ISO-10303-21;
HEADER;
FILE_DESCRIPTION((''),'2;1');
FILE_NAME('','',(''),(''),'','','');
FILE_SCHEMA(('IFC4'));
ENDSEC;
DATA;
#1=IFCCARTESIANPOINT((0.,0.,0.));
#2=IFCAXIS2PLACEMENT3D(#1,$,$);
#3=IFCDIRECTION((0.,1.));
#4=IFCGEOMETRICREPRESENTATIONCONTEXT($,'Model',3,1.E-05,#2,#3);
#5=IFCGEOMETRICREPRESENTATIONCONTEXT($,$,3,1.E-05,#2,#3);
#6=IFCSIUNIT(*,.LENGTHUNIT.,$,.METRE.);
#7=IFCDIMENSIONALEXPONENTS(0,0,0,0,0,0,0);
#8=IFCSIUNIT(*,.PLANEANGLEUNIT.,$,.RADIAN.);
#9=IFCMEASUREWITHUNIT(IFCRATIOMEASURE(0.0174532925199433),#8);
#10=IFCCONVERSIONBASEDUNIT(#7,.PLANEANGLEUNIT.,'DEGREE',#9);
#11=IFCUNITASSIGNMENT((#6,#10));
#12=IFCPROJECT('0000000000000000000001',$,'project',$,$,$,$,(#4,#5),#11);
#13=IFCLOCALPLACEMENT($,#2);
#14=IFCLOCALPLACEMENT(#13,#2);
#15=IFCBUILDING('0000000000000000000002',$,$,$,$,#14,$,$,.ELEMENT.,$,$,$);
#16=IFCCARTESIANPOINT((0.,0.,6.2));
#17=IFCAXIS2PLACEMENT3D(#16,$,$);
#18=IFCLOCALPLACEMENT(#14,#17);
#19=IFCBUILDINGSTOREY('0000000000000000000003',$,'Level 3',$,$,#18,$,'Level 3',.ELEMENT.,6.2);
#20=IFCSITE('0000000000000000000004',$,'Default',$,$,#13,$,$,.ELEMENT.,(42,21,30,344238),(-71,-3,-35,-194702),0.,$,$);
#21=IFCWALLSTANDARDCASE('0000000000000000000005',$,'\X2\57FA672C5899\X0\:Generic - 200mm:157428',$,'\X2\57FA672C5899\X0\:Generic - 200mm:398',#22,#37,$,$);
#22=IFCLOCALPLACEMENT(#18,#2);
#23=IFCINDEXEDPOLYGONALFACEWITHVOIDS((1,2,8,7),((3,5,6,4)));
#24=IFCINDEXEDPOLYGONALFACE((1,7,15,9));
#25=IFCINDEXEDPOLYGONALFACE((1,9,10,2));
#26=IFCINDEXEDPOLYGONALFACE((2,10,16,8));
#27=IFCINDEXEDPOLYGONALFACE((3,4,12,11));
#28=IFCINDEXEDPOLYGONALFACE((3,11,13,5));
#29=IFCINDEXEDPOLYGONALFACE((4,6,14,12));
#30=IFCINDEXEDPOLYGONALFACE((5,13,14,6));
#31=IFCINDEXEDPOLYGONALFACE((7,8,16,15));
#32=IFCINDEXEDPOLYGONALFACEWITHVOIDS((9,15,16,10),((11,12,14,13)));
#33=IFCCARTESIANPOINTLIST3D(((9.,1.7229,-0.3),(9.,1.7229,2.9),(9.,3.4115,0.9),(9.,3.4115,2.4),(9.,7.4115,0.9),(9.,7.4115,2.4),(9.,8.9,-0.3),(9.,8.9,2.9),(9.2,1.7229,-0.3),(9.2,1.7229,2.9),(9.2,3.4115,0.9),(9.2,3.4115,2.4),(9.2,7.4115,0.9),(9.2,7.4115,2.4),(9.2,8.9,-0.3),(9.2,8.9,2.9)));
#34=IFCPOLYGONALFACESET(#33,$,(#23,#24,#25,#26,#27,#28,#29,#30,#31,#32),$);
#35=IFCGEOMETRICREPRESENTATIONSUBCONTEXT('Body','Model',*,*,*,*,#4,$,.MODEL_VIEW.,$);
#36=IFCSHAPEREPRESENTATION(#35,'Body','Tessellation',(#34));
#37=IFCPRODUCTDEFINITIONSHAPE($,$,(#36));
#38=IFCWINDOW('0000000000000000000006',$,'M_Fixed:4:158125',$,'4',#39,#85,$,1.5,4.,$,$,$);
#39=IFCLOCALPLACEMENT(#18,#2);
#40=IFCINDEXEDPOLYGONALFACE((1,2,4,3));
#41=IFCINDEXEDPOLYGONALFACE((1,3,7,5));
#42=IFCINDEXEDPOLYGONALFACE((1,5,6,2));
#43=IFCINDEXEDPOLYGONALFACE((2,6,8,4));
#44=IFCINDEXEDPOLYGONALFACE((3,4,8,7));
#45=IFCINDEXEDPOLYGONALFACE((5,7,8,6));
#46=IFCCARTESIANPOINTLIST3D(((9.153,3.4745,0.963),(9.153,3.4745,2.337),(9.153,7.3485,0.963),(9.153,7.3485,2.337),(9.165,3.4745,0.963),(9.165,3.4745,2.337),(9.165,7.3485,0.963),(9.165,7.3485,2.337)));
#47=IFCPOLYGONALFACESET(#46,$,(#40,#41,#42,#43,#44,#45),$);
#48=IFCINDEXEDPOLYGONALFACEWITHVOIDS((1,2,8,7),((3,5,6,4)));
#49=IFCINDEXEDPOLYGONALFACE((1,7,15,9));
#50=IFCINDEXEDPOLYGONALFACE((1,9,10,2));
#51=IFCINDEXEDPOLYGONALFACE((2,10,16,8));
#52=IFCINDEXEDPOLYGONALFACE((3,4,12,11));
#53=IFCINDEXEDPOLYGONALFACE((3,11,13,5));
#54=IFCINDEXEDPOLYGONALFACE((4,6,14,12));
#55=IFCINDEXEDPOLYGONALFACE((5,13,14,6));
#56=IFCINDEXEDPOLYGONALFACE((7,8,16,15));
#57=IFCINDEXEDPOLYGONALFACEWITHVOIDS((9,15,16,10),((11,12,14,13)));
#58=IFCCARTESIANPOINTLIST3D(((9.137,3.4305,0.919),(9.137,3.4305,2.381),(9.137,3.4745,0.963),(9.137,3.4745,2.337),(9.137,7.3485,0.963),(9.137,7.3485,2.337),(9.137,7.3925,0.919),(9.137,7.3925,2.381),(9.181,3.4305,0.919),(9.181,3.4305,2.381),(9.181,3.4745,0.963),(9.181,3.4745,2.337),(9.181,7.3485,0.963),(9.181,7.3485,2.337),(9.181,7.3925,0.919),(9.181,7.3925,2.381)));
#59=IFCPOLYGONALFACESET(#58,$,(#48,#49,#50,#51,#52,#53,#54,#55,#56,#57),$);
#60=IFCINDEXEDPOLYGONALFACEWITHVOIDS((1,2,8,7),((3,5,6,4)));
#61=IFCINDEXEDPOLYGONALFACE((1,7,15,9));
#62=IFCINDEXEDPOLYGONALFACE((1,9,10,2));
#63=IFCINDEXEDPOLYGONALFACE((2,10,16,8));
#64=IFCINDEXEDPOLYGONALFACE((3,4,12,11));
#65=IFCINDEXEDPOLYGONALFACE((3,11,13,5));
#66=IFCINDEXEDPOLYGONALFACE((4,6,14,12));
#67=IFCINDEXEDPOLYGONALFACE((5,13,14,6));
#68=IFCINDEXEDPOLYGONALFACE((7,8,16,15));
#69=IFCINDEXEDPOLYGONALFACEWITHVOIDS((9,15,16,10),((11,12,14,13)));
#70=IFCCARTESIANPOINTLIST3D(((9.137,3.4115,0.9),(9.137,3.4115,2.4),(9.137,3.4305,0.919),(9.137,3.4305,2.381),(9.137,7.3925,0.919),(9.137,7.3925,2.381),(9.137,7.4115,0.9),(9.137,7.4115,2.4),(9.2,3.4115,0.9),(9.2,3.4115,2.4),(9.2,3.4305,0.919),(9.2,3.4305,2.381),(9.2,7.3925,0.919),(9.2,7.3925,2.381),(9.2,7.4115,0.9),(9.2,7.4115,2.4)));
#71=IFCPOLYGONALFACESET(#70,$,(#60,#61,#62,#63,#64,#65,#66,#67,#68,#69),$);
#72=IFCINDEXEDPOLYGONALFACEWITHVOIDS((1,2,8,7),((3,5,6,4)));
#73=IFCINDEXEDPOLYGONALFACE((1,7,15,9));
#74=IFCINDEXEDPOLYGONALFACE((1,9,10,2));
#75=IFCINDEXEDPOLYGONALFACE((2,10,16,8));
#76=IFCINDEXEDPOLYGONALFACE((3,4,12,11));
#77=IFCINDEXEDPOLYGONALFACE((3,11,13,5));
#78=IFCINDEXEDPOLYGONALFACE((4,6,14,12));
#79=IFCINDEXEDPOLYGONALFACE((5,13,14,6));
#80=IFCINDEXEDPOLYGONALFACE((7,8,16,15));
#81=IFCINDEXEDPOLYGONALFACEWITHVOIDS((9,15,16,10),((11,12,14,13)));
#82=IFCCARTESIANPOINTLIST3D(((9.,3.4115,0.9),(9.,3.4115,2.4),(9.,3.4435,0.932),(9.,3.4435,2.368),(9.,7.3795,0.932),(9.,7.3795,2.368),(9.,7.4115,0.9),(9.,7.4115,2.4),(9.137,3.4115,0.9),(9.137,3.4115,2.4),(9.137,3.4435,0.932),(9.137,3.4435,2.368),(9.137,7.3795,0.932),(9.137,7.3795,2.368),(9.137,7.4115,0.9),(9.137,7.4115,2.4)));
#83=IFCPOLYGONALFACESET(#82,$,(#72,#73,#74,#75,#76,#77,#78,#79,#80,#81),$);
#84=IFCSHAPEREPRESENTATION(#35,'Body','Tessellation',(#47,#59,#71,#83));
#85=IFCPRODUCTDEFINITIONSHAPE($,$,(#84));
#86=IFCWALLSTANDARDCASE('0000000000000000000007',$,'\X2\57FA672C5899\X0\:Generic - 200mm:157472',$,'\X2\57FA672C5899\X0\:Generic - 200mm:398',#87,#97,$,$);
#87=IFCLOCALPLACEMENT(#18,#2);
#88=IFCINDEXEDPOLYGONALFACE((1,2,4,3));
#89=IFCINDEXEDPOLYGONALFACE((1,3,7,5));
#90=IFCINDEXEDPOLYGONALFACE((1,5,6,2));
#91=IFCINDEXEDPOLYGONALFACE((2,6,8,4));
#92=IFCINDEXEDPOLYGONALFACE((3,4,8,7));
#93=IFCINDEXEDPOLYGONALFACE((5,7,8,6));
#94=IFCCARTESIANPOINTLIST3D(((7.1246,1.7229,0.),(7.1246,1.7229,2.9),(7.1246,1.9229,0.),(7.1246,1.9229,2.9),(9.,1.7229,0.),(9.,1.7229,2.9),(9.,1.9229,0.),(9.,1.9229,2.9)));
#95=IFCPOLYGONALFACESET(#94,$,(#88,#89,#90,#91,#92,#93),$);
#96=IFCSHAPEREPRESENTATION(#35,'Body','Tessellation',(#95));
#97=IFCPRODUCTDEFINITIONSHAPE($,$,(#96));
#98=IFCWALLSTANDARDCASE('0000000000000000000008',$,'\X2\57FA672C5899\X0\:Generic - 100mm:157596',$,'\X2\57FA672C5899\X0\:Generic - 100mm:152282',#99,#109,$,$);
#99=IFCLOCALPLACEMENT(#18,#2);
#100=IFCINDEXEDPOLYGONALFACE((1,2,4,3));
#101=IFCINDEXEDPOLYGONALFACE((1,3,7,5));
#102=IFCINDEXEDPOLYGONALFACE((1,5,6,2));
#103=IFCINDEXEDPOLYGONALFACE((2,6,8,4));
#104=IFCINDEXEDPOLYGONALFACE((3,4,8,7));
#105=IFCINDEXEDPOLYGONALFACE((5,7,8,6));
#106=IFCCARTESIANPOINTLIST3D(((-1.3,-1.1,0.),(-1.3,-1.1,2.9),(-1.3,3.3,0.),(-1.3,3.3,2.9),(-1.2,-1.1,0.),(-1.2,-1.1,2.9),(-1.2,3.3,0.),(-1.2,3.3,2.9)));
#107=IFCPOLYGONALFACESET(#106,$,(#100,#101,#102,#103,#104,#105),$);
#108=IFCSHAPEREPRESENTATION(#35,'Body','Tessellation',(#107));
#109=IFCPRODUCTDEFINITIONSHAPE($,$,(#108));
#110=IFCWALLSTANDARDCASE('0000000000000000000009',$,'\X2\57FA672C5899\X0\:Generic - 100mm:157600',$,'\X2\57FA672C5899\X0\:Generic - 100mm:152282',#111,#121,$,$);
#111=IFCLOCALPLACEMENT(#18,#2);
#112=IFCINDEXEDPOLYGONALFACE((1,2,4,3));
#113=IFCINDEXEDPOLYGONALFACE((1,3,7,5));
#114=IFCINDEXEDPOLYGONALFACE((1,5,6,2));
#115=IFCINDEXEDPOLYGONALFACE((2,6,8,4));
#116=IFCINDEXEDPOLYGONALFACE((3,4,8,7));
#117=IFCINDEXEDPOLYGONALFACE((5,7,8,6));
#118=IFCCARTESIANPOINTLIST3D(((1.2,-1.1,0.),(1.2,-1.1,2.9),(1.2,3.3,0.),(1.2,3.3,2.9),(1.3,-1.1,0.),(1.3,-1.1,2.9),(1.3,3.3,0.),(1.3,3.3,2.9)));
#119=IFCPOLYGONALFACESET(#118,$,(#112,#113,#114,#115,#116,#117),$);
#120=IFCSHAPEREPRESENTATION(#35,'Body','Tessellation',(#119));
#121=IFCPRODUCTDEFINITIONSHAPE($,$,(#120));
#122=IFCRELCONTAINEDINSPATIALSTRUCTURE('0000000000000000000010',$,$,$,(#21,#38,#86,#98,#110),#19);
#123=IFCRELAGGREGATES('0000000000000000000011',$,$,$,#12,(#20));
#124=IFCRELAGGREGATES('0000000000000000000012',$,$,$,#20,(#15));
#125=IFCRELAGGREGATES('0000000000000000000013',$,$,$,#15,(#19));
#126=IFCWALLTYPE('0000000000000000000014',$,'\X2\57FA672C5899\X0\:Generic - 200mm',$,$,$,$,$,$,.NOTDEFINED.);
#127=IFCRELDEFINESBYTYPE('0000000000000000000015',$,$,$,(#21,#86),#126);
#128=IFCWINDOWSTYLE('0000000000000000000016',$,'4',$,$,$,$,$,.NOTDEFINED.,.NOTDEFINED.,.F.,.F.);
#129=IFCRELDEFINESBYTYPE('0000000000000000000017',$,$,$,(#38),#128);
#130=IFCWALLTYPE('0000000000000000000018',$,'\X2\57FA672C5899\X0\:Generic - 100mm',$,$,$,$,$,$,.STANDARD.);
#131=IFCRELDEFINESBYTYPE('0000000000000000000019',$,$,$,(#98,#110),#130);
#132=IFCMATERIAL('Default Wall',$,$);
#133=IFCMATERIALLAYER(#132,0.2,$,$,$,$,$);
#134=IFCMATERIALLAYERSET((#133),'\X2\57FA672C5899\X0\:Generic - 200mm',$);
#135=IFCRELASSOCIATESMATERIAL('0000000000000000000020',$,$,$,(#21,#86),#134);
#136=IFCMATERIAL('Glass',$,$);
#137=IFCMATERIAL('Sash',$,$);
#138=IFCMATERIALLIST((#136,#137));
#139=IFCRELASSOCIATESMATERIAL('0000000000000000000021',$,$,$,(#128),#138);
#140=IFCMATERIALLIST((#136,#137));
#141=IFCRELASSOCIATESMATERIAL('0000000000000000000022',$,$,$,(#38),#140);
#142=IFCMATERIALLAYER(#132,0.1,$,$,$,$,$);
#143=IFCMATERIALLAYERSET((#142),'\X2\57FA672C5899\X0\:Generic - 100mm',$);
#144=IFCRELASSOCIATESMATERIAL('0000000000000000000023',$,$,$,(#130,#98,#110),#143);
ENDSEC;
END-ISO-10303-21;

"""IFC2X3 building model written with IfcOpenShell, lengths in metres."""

from ifc_helpers import new_model, entity, si_unit, converted_unit, direction, frame, frame_2d, origin, place, context, subcontext, project, spatial, polyline, rectangle, outline, extrude, clip, bounded_halfspace, source, transform, mapped, material, material_list, layer, layer_set, layer_usage, type_object, type_shapes, element, fill, save


model = new_model("IFC2X3")

# Units and contexts
model_context = context("Model", 3, precision=1e-05, world=origin(), true_north=direction((0.0, 1.0)))
context_of_model = context(None, 3, precision=1e-05, world=origin(), true_north=direction((0.0, 1.0)))
body_context = subcontext(model_context, "Body", "Model", "MODEL_VIEW")
ifc_project = project(units=[si_unit("LENGTHUNIT", "METRE"), converted_unit("PLANEANGLEUNIT", "DEGREE", entity("IfcRatioMeasure", 0.0174532925199433), si_unit("PLANEANGLEUNIT", "RADIAN"), dimensions=[0, 0, 0, 0, 0, 0, 0])], contexts=[model_context, context_of_model])

# Site, building, storey
site_placement = place(None, origin())
site = spatial("IfcSite", under=ifc_project, at=site_placement, Name="Default", CompositionType="ELEMENT", RefLatitude=(42, 21, 30, 344238), RefLongitude=(-71, -3, -35, -194702), RefElevation=0.0)
building_placement = place(site_placement, origin())
building = spatial("IfcBuilding", under=site, at=building_placement, CompositionType="ELEMENT")
storey_placement = place(building_placement, frame((0.0, 0.0, 6.2)))
storey = spatial("IfcBuildingStorey", under=building, at=storey_placement, Name="Level 3", LongName="Level 3", CompositionType="ELEMENT", Elevation=6.2)

# Shared definitions
ifc_material_1 = material(Name="Default Wall")
ifc_layer_1 = layer(ifc_material_1, 0.2)
ifc_layer_set_1 = layer_set([ifc_layer_1], Name="基本墙:Generic - 200mm")
wall_type_1 = type_object("IfcWallType", Name="基本墙:Generic - 200mm", PredefinedType="NOTDEFINED")

# Shared definitions
ifc_material_2 = material(Name="Glass")

# Wall, opening, window
ifc_layer_usage_1 = layer_usage(ifc_layer_set_1, "AXIS2", "NEGATIVE", 0.1)
wall_1_placement = place(storey_placement, frame((9.1, 8.9, -0.3), z_axis=(0.0, 0.0, 1.0), x_axis=(0.0, -1.0, 0.0)))
wall_1 = element("IfcWallStandardCase", 1, at=wall_1_placement, inside=storey, type_object=wall_type_1, material=ifc_layer_usage_1, Name="基本墙:Generic - 200mm:157428", ObjectType="基本墙:Generic - 200mm:398", context=body_context, shape_type="Clipping", body=[
    clip(extrude(rectangle(XDim=7.1771, YDim=0.2, at=frame_2d((3.5885, 0.0), x_axis=(-1.0, 0.0))), origin(), (0.0, 0.0, 1.0), 3.5), bounded_halfspace(frame((0.0, -0.1, 3.2), z_axis=(0.0, 0.0, -1.0), x_axis=(1.0, 0.0, 0.0)), True, frame((0.0, -0.1, 3.2), z_axis=(0.0, 0.0, -1.0), x_axis=(1.0, 0.0, 0.0)), polyline([(0.0, 0.0), (0.0, -0.1), (0.0, -0.2), (7.1771, -0.2), (7.1771, 0.0), (6.9771, 0.0), (0.0, 0.0)]))),
])
opening_1_placement = place(wall_1_placement, frame((1.4885, -0.1, 1.2)))
opening_1 = element("IfcOpeningElement", 2, at=opening_1_placement, cuts=wall_1, ObjectType="Opening", context=body_context, shape_type="SweptSolid", body=[
    extrude(rectangle(XDim=1.5, YDim=4.0, at=frame_2d((0.75, 2.0), x_axis=(1.0, 0.0))), frame((0.0, 0.0, 0.0), z_axis=(0.0, 1.0, 0.0), x_axis=(0.0, 0.0, 1.0)), (0.0, 0.0, 1.0), 0.2),
])
ifc_material_3 = material(Name="Sash")
ifc_material_list_1 = material_list([ifc_material_2, ifc_material_3])
ifc_material_list_2 = material_list([ifc_material_2, ifc_material_3])
window_style = type_object("IfcWindowStyle", Name="4", ConstructionType="NOTDEFINED", OperationType="NOTDEFINED", ParameterTakesPrecedence=False, Sizeable=False, material=ifc_material_list_2)
shared_shape_1 = source(origin(), body_context, "Body", "SweptSolid", [
    extrude(rectangle(XDim=0.012, YDim=3.874, at=frame_2d((0.0, 0.0), x_axis=(1.0, 0.0))), frame((2.0, 0.159, 0.063), z_axis=(0.0, 0.0, 1.0), x_axis=(0.0, -1.0, 0.0)), (0.0, 0.0, 1.0), 1.374),
    extrude(outline(polyline([(-1.981, -0.731), (1.981, -0.731), (1.981, 0.731), (-1.981, 0.731), (-1.981, -0.731)]), holes=[polyline([(-1.937, -0.687), (-1.937, 0.687), (1.937, 0.687), (1.937, -0.687), (-1.937, -0.687)])]), frame((2.0, 0.137, 0.75), z_axis=(0.0, 1.0, 0.0), x_axis=(1.0, 0.0, 0.0)), (0.0, 0.0, 1.0), 0.044),
    extrude(outline(polyline([(-2.0, -0.75), (2.0, -0.75), (2.0, 0.75), (-2.0, 0.75), (-2.0, -0.75)]), holes=[polyline([(-1.981, -0.731), (-1.981, 0.731), (1.981, 0.731), (1.981, -0.731), (-1.981, -0.731)])]), frame((2.0, 0.137, 0.75), z_axis=(0.0, 1.0, 0.0), x_axis=(1.0, 0.0, 0.0)), (0.0, 0.0, 1.0), 0.063),
    extrude(outline(polyline([(-2.0, -0.75), (2.0, -0.75), (2.0, 0.75), (-2.0, 0.75), (-2.0, -0.75)]), holes=[polyline([(-1.968, -0.718), (-1.968, 0.718), (1.968, 0.718), (1.968, -0.718), (-1.968, -0.718)])]), frame((2.0, 0.0, 0.75), z_axis=(0.0, 1.0, 0.0), x_axis=(1.0, 0.0, 0.0)), (0.0, 0.0, 1.0), 0.137),
])
type_shapes(window_style, [shared_shape_1])
window_placement = place(opening_1_placement, origin())
window = element("IfcWindow", 3, at=window_placement, inside=storey, type_object=window_style, material=ifc_material_list_1, Name="M_Fixed:4:158125", ObjectType="4", OverallHeight=1.5, OverallWidth=4.0, context=body_context, shape_type="MappedRepresentation", body=[
    mapped(shared_shape_1, transform((0.0, 0.0, 0.0), scale=1.0)),
])
fill(opening_1, window)

# Wall
ifc_layer_usage_2 = layer_usage(ifc_layer_set_1, "AXIS2", "NEGATIVE", 0.1)
wall_2_placement = place(storey_placement, frame((9.0, 1.8229, 0.0), z_axis=(0.0, 0.0, 1.0), x_axis=(-1.0, 0.0, 0.0)))
element("IfcWallStandardCase", 4, at=wall_2_placement, inside=storey, type_object=wall_type_1, material=ifc_layer_usage_2, Name="基本墙:Generic - 200mm:157472", ObjectType="基本墙:Generic - 200mm:398", context=body_context, shape_type="Clipping", body=[
    clip(extrude(rectangle(XDim=1.8754, YDim=0.2, at=frame_2d((0.9377, 0.0), x_axis=(-1.0, 0.0))), origin(), (0.0, 0.0, 1.0), 3.2), bounded_halfspace(frame((0.0, -0.1, 2.9), z_axis=(0.0, 0.0, -1.0), x_axis=(0.0, 1.0, 0.0)), True, frame((0.0, -0.1, 2.9), z_axis=(0.0, 0.0, -1.0), x_axis=(0.0, 1.0, 0.0)), polyline([(0.0, 0.0), (0.2, 0.0), (0.2, 1.6754), (0.2, 1.8754), (0.0, 1.8754), (0.0, 0.0)]))),
])

# Walls
ifc_layer_2 = layer(ifc_material_1, 0.1)
ifc_layer_set_2 = layer_set([ifc_layer_2], Name="基本墙:Generic - 100mm")
ifc_layer_usage_3 = layer_usage(ifc_layer_set_2, "AXIS2", "NEGATIVE", 0.05)
wall_type_2 = type_object("IfcWallType", Name="基本墙:Generic - 100mm", PredefinedType="STANDARD", material=ifc_layer_set_2)
wall_3_placement = place(storey_placement, frame((-1.25, -1.1, 0.0), z_axis=(0.0, 0.0, 1.0), x_axis=(0.0, 1.0, 0.0)))
element("IfcWallStandardCase", 5, at=wall_3_placement, inside=storey, type_object=wall_type_2, material=ifc_layer_usage_3, Name="基本墙:Generic - 100mm:157596", ObjectType="基本墙:Generic - 100mm:152282", context=body_context, shape_type="Clipping", body=[
    clip(extrude(rectangle(XDim=4.4, YDim=0.1, at=frame_2d((2.2, 0.0), x_axis=(-1.0, 0.0))), origin(), (0.0, 0.0, 1.0), 3.2), bounded_halfspace(frame((0.0, -0.05, 2.9), z_axis=(0.0, 0.0, -1.0), x_axis=(-1.0, 0.0, 0.0)), True, frame((0.0, -0.05, 2.9), z_axis=(0.0, 0.0, -1.0), x_axis=(-1.0, 0.0, 0.0)), polyline([(0.0, 0.0), (0.0, 0.1), (-4.4, 0.1), (-4.4, 0.0), (-4.3, 0.0), (0.0, 0.0)]))),
])
ifc_layer_usage_4 = layer_usage(ifc_layer_set_2, "AXIS2", "NEGATIVE", 0.05)
wall_4_placement = place(storey_placement, frame((1.25, -1.1, 0.0), z_axis=(0.0, 0.0, 1.0), x_axis=(0.0, 1.0, 0.0)))
element("IfcWallStandardCase", 6, at=wall_4_placement, inside=storey, type_object=wall_type_2, material=ifc_layer_usage_4, Name="基本墙:Generic - 100mm:157600", ObjectType="基本墙:Generic - 100mm:152282", context=body_context, shape_type="Clipping", body=[
    clip(extrude(rectangle(XDim=4.4, YDim=0.1, at=frame_2d((2.2, 0.0), x_axis=(-1.0, 0.0))), origin(), (0.0, 0.0, 1.0), 3.2), bounded_halfspace(frame((0.0, -0.05, 2.9), z_axis=(0.0, 0.0, -1.0), x_axis=(-1.0, 0.0, 0.0)), True, frame((0.0, -0.05, 2.9), z_axis=(0.0, 0.0, -1.0), x_axis=(-1.0, 0.0, 0.0)), polyline([(0.0, 0.0), (0.0, 0.1), (-4.3, 0.1), (-4.4, 0.1), (-4.4, 0.0), (0.0, 0.0)]))),
])

save(model, "model.ifc")
